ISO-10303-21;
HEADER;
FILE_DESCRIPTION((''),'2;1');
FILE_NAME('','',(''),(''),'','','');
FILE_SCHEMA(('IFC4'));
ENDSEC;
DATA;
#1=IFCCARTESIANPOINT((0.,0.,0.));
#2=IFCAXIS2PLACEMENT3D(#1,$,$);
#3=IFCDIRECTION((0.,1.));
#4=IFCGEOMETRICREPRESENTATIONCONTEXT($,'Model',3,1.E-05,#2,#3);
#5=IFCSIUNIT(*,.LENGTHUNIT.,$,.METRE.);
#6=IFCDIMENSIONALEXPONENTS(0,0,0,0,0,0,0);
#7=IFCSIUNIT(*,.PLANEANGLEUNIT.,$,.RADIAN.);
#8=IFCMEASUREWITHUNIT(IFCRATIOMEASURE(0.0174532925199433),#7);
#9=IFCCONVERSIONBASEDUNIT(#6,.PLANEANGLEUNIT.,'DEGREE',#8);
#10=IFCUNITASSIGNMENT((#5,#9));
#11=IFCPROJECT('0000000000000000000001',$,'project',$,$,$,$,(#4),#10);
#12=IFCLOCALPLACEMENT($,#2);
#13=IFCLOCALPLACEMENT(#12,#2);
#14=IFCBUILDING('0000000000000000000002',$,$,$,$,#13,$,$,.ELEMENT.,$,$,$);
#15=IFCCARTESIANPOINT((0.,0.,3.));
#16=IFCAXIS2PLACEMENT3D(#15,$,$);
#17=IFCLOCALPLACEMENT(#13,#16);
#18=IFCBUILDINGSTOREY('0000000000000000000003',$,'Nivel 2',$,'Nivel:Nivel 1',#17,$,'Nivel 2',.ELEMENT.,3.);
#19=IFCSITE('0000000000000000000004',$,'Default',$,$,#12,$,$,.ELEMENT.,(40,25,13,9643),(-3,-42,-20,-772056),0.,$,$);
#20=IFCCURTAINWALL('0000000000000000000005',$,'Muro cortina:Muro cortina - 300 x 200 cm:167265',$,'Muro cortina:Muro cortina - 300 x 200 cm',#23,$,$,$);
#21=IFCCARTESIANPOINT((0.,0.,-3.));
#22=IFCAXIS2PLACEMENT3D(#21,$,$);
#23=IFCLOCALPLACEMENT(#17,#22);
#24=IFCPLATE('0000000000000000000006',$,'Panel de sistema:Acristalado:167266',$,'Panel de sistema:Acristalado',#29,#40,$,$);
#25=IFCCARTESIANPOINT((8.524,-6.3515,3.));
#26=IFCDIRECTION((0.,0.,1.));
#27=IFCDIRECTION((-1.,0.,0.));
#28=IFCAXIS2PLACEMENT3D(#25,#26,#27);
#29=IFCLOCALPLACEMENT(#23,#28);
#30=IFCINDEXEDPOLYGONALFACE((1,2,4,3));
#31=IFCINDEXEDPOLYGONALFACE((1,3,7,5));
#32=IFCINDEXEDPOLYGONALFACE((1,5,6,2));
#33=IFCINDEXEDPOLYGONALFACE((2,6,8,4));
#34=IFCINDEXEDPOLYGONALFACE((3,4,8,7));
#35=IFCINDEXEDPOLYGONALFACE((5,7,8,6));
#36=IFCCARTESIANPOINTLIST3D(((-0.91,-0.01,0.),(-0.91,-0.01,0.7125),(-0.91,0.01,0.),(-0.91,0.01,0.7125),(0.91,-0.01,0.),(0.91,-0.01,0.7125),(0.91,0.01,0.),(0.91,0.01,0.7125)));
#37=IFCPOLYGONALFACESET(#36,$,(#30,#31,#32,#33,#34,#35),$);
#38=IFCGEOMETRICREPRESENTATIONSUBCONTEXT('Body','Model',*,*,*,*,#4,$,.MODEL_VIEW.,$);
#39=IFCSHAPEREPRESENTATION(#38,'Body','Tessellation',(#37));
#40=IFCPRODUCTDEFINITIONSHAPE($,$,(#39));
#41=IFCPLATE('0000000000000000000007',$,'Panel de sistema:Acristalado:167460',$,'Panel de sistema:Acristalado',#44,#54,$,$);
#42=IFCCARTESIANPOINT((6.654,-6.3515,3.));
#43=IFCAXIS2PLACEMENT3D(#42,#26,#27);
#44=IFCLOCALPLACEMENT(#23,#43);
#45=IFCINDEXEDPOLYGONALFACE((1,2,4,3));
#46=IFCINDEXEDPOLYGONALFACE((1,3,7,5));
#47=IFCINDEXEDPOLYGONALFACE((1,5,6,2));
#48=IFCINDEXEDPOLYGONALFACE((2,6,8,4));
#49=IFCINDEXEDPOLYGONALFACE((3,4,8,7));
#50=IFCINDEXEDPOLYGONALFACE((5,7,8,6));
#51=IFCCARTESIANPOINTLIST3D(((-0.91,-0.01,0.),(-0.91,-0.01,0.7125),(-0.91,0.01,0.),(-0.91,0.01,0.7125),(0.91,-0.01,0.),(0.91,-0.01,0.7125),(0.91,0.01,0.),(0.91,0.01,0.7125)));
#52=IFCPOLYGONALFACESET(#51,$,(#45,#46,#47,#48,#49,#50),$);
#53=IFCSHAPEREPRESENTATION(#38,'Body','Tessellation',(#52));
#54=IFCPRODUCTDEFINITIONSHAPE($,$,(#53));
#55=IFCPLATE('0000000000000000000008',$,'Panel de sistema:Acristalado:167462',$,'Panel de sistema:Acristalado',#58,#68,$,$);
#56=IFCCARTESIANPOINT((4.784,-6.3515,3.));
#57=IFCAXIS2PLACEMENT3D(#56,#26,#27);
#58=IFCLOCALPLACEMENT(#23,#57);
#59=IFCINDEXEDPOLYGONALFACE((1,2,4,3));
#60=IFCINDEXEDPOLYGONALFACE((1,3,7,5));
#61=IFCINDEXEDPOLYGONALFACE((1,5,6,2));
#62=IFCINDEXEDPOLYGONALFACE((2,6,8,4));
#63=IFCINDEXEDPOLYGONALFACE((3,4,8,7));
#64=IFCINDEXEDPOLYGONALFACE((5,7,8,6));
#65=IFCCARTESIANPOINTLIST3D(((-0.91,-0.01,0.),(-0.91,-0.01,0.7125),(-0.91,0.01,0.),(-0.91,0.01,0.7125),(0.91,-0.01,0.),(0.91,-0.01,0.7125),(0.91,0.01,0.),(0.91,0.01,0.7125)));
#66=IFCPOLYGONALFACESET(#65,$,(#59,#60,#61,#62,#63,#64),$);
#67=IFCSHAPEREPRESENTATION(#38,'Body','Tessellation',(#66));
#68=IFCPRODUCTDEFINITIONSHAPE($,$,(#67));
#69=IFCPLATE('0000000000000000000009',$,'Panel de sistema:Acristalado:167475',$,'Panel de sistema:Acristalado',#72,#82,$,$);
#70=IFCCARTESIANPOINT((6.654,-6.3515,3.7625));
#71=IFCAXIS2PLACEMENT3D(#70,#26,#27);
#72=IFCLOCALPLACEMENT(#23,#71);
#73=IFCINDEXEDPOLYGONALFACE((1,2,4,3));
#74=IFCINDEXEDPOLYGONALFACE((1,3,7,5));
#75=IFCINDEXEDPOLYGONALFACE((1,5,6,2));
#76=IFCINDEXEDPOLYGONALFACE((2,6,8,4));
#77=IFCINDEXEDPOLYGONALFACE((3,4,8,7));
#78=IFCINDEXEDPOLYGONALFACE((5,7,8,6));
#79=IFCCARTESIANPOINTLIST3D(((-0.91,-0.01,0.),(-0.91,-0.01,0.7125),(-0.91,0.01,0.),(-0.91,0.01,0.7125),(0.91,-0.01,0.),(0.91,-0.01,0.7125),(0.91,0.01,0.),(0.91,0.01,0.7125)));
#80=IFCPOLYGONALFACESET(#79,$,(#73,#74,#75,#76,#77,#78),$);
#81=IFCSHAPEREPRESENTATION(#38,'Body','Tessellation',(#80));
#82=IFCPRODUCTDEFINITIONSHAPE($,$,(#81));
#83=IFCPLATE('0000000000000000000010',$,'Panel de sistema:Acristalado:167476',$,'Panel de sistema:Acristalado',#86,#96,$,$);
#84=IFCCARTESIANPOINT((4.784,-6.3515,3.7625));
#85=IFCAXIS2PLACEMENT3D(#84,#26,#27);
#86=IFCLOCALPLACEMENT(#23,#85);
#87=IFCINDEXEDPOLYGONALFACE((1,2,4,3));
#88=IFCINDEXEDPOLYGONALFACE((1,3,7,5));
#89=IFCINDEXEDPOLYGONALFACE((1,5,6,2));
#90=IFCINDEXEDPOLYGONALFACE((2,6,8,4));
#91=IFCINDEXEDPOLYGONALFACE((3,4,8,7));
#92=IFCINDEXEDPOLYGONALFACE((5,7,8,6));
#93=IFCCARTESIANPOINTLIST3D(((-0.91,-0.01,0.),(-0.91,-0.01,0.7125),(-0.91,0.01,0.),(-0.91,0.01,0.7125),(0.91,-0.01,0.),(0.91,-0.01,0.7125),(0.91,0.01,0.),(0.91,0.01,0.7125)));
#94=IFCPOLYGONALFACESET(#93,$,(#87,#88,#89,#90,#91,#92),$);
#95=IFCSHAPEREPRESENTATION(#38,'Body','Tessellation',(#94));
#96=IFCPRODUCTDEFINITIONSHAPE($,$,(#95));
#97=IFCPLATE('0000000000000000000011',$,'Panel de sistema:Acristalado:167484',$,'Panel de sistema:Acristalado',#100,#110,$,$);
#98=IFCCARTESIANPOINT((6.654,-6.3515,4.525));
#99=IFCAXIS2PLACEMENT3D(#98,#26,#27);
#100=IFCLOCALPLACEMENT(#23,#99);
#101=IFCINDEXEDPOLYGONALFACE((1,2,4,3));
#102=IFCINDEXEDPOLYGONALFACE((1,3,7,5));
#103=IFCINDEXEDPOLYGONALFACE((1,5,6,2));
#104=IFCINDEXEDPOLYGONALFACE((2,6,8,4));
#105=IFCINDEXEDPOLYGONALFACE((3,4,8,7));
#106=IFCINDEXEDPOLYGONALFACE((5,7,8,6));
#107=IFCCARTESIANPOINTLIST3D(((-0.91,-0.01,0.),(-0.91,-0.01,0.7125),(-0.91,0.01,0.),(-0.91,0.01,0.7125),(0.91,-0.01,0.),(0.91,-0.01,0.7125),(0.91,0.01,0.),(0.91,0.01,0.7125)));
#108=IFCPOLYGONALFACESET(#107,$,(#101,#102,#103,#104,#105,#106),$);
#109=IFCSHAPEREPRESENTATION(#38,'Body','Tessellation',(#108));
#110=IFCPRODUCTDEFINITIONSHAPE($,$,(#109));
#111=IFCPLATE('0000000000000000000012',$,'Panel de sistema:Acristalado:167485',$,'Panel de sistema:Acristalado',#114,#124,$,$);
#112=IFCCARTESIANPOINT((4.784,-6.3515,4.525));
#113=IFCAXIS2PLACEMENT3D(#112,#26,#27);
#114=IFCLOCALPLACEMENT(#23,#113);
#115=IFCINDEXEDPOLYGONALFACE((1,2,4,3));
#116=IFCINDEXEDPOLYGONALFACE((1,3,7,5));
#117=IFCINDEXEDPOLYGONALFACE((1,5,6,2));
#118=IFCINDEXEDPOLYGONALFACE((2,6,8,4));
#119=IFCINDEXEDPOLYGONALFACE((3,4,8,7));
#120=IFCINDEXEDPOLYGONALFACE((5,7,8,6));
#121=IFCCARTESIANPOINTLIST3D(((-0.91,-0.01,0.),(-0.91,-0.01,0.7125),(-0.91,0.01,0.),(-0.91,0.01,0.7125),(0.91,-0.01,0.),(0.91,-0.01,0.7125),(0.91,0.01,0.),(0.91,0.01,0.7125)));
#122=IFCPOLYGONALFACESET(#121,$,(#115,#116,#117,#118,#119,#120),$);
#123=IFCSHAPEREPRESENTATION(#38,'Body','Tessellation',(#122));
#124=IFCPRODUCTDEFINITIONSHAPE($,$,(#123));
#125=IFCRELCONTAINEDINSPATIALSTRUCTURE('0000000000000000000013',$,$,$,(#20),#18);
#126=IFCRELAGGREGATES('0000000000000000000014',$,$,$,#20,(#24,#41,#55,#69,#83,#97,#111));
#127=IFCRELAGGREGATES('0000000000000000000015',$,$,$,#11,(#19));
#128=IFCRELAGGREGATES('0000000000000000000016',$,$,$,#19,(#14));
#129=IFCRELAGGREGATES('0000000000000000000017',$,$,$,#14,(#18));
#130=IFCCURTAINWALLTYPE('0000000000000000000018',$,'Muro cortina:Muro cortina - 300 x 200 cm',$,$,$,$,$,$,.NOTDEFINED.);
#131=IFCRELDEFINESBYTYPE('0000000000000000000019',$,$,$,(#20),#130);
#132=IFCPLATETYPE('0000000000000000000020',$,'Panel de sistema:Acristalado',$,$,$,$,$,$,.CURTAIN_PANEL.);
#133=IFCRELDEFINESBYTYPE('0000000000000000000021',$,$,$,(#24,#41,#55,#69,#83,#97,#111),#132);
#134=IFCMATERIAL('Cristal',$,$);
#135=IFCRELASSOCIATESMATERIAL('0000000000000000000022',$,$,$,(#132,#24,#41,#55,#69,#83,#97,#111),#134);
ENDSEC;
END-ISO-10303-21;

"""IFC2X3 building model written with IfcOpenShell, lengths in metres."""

from ifc_helpers import new_model, entity, si_unit, converted_unit, direction, frame, origin, origin_2d_with_axis, place, context, subcontext, project, spatial, rectangle, extrude, source, transform, mapped, material, type_object, type_shapes, element, aggregate, save


model = new_model("IFC2X3")

# Units and contexts
model_context = context("Model", 3, precision=1e-05, world=origin(), true_north=direction((0.0, 1.0)))
body_context = subcontext(model_context, "Body", "Model", "MODEL_VIEW")
ifc_project = project(units=[si_unit("LENGTHUNIT", "METRE"), converted_unit("PLANEANGLEUNIT", "DEGREE", entity("IfcRatioMeasure", 0.0174532925199433), si_unit("PLANEANGLEUNIT", "RADIAN"), dimensions=[0, 0, 0, 0, 0, 0, 0])], contexts=[model_context])

# Site, building, storey
site_placement = place(None, origin())
site = spatial("IfcSite", under=ifc_project, at=site_placement, Name="Default", CompositionType="ELEMENT", RefLatitude=(40, 25, 13, 9643), RefLongitude=(-3, -42, -20, -772056), RefElevation=0.0)
building_placement = place(site_placement, origin())
building = spatial("IfcBuilding", under=site, at=building_placement, CompositionType="ELEMENT")
storey_placement = place(building_placement, frame((0.0, 0.0, 3.0)))
storey = spatial("IfcBuildingStorey", under=building, at=storey_placement, Name="Nivel 2", ObjectType="Nivel:Nivel 1", LongName="Nivel 2", CompositionType="ELEMENT", Elevation=3.0)

# Curtain wall, plates
curtain_wall_type = type_object("IfcCurtainWallType", Name="Muro cortina:Muro cortina - 300 x 200 cm", PredefinedType="NOTDEFINED")
curtain_wall_placement = place(storey_placement, frame((0.0, 0.0, -3.0)))
curtain_wall = element("IfcCurtainWall", 1, at=curtain_wall_placement, inside=storey, type_object=curtain_wall_type, Name="Muro cortina:Muro cortina - 300 x 200 cm:167265", ObjectType="Muro cortina:Muro cortina - 300 x 200 cm")
ifc_material_1 = material(Name="Cristal")
plate_type = type_object("IfcPlateType", Name="Panel de sistema:Acristalado", PredefinedType="CURTAIN_PANEL", material=ifc_material_1)
shared_shape_1 = source(origin(), body_context, "Body", "SweptSolid", [
    extrude(rectangle(XDim=0.02, YDim=1.82, at=origin_2d_with_axis()), frame((0.0, 0.0, 0.0), z_axis=(0.0, 0.0, 1.0), x_axis=(0.0, 1.0, 0.0)), (0.0, 0.0, 1.0), 0.7125),
])
type_shapes(plate_type, [shared_shape_1])
plate_1_placement = place(curtain_wall_placement, frame((8.524, -6.3515, 3.0), z_axis=(0.0, 0.0, 1.0), x_axis=(-1.0, 0.0, 0.0)))
plate_1 = element("IfcPlate", 2, at=plate_1_placement, type_object=plate_type, material=ifc_material_1, Name="Panel de sistema:Acristalado:167266", ObjectType="Panel de sistema:Acristalado", context=body_context, shape_type="MappedRepresentation", body=[
    mapped(shared_shape_1, transform((0.0, 0.0, 0.0), scale=1.0)),
])
plate_2_placement = place(curtain_wall_placement, frame((6.654, -6.3515, 3.0), z_axis=(0.0, 0.0, 1.0), x_axis=(-1.0, 0.0, 0.0)))
plate_2 = element("IfcPlate", 3, at=plate_2_placement, type_object=plate_type, material=ifc_material_1, Name="Panel de sistema:Acristalado:167460", ObjectType="Panel de sistema:Acristalado", context=body_context, shape_type="MappedRepresentation", body=[
    mapped(shared_shape_1, transform((0.0, 0.0, 0.0), scale=1.0)),
])
plate_3_placement = place(curtain_wall_placement, frame((4.784, -6.3515, 3.0), z_axis=(0.0, 0.0, 1.0), x_axis=(-1.0, 0.0, 0.0)))
plate_3 = element("IfcPlate", 4, at=plate_3_placement, type_object=plate_type, material=ifc_material_1, Name="Panel de sistema:Acristalado:167462", ObjectType="Panel de sistema:Acristalado", context=body_context, shape_type="MappedRepresentation", body=[
    mapped(shared_shape_1, transform((0.0, 0.0, 0.0), scale=1.0)),
])
plate_4_placement = place(curtain_wall_placement, frame((6.654, -6.3515, 3.7625), z_axis=(0.0, 0.0, 1.0), x_axis=(-1.0, 0.0, 0.0)))
plate_4 = element("IfcPlate", 5, at=plate_4_placement, type_object=plate_type, material=ifc_material_1, Name="Panel de sistema:Acristalado:167475", ObjectType="Panel de sistema:Acristalado", context=body_context, shape_type="MappedRepresentation", body=[
    mapped(shared_shape_1, transform((0.0, 0.0, 0.0), scale=1.0)),
])
plate_5_placement = place(curtain_wall_placement, frame((4.784, -6.3515, 3.7625), z_axis=(0.0, 0.0, 1.0), x_axis=(-1.0, 0.0, 0.0)))
plate_5 = element("IfcPlate", 6, at=plate_5_placement, type_object=plate_type, material=ifc_material_1, Name="Panel de sistema:Acristalado:167476", ObjectType="Panel de sistema:Acristalado", context=body_context, shape_type="MappedRepresentation", body=[
    mapped(shared_shape_1, transform((0.0, 0.0, 0.0), scale=1.0)),
])
plate_6_placement = place(curtain_wall_placement, frame((6.654, -6.3515, 4.525), z_axis=(0.0, 0.0, 1.0), x_axis=(-1.0, 0.0, 0.0)))
plate_6 = element("IfcPlate", 7, at=plate_6_placement, type_object=plate_type, material=ifc_material_1, Name="Panel de sistema:Acristalado:167484", ObjectType="Panel de sistema:Acristalado", context=body_context, shape_type="MappedRepresentation", body=[
    mapped(shared_shape_1, transform((0.0, 0.0, 0.0), scale=1.0)),
])
plate_7_placement = place(curtain_wall_placement, frame((4.784, -6.3515, 4.525), z_axis=(0.0, 0.0, 1.0), x_axis=(-1.0, 0.0, 0.0)))
plate_7 = element("IfcPlate", 8, at=plate_7_placement, type_object=plate_type, material=ifc_material_1, Name="Panel de sistema:Acristalado:167485", ObjectType="Panel de sistema:Acristalado", context=body_context, shape_type="MappedRepresentation", body=[
    mapped(shared_shape_1, transform((0.0, 0.0, 0.0), scale=1.0)),
])
aggregate(curtain_wall, [plate_1, plate_2, plate_3, plate_4, plate_5, plate_6, plate_7])

save(model, "model.ifc")
